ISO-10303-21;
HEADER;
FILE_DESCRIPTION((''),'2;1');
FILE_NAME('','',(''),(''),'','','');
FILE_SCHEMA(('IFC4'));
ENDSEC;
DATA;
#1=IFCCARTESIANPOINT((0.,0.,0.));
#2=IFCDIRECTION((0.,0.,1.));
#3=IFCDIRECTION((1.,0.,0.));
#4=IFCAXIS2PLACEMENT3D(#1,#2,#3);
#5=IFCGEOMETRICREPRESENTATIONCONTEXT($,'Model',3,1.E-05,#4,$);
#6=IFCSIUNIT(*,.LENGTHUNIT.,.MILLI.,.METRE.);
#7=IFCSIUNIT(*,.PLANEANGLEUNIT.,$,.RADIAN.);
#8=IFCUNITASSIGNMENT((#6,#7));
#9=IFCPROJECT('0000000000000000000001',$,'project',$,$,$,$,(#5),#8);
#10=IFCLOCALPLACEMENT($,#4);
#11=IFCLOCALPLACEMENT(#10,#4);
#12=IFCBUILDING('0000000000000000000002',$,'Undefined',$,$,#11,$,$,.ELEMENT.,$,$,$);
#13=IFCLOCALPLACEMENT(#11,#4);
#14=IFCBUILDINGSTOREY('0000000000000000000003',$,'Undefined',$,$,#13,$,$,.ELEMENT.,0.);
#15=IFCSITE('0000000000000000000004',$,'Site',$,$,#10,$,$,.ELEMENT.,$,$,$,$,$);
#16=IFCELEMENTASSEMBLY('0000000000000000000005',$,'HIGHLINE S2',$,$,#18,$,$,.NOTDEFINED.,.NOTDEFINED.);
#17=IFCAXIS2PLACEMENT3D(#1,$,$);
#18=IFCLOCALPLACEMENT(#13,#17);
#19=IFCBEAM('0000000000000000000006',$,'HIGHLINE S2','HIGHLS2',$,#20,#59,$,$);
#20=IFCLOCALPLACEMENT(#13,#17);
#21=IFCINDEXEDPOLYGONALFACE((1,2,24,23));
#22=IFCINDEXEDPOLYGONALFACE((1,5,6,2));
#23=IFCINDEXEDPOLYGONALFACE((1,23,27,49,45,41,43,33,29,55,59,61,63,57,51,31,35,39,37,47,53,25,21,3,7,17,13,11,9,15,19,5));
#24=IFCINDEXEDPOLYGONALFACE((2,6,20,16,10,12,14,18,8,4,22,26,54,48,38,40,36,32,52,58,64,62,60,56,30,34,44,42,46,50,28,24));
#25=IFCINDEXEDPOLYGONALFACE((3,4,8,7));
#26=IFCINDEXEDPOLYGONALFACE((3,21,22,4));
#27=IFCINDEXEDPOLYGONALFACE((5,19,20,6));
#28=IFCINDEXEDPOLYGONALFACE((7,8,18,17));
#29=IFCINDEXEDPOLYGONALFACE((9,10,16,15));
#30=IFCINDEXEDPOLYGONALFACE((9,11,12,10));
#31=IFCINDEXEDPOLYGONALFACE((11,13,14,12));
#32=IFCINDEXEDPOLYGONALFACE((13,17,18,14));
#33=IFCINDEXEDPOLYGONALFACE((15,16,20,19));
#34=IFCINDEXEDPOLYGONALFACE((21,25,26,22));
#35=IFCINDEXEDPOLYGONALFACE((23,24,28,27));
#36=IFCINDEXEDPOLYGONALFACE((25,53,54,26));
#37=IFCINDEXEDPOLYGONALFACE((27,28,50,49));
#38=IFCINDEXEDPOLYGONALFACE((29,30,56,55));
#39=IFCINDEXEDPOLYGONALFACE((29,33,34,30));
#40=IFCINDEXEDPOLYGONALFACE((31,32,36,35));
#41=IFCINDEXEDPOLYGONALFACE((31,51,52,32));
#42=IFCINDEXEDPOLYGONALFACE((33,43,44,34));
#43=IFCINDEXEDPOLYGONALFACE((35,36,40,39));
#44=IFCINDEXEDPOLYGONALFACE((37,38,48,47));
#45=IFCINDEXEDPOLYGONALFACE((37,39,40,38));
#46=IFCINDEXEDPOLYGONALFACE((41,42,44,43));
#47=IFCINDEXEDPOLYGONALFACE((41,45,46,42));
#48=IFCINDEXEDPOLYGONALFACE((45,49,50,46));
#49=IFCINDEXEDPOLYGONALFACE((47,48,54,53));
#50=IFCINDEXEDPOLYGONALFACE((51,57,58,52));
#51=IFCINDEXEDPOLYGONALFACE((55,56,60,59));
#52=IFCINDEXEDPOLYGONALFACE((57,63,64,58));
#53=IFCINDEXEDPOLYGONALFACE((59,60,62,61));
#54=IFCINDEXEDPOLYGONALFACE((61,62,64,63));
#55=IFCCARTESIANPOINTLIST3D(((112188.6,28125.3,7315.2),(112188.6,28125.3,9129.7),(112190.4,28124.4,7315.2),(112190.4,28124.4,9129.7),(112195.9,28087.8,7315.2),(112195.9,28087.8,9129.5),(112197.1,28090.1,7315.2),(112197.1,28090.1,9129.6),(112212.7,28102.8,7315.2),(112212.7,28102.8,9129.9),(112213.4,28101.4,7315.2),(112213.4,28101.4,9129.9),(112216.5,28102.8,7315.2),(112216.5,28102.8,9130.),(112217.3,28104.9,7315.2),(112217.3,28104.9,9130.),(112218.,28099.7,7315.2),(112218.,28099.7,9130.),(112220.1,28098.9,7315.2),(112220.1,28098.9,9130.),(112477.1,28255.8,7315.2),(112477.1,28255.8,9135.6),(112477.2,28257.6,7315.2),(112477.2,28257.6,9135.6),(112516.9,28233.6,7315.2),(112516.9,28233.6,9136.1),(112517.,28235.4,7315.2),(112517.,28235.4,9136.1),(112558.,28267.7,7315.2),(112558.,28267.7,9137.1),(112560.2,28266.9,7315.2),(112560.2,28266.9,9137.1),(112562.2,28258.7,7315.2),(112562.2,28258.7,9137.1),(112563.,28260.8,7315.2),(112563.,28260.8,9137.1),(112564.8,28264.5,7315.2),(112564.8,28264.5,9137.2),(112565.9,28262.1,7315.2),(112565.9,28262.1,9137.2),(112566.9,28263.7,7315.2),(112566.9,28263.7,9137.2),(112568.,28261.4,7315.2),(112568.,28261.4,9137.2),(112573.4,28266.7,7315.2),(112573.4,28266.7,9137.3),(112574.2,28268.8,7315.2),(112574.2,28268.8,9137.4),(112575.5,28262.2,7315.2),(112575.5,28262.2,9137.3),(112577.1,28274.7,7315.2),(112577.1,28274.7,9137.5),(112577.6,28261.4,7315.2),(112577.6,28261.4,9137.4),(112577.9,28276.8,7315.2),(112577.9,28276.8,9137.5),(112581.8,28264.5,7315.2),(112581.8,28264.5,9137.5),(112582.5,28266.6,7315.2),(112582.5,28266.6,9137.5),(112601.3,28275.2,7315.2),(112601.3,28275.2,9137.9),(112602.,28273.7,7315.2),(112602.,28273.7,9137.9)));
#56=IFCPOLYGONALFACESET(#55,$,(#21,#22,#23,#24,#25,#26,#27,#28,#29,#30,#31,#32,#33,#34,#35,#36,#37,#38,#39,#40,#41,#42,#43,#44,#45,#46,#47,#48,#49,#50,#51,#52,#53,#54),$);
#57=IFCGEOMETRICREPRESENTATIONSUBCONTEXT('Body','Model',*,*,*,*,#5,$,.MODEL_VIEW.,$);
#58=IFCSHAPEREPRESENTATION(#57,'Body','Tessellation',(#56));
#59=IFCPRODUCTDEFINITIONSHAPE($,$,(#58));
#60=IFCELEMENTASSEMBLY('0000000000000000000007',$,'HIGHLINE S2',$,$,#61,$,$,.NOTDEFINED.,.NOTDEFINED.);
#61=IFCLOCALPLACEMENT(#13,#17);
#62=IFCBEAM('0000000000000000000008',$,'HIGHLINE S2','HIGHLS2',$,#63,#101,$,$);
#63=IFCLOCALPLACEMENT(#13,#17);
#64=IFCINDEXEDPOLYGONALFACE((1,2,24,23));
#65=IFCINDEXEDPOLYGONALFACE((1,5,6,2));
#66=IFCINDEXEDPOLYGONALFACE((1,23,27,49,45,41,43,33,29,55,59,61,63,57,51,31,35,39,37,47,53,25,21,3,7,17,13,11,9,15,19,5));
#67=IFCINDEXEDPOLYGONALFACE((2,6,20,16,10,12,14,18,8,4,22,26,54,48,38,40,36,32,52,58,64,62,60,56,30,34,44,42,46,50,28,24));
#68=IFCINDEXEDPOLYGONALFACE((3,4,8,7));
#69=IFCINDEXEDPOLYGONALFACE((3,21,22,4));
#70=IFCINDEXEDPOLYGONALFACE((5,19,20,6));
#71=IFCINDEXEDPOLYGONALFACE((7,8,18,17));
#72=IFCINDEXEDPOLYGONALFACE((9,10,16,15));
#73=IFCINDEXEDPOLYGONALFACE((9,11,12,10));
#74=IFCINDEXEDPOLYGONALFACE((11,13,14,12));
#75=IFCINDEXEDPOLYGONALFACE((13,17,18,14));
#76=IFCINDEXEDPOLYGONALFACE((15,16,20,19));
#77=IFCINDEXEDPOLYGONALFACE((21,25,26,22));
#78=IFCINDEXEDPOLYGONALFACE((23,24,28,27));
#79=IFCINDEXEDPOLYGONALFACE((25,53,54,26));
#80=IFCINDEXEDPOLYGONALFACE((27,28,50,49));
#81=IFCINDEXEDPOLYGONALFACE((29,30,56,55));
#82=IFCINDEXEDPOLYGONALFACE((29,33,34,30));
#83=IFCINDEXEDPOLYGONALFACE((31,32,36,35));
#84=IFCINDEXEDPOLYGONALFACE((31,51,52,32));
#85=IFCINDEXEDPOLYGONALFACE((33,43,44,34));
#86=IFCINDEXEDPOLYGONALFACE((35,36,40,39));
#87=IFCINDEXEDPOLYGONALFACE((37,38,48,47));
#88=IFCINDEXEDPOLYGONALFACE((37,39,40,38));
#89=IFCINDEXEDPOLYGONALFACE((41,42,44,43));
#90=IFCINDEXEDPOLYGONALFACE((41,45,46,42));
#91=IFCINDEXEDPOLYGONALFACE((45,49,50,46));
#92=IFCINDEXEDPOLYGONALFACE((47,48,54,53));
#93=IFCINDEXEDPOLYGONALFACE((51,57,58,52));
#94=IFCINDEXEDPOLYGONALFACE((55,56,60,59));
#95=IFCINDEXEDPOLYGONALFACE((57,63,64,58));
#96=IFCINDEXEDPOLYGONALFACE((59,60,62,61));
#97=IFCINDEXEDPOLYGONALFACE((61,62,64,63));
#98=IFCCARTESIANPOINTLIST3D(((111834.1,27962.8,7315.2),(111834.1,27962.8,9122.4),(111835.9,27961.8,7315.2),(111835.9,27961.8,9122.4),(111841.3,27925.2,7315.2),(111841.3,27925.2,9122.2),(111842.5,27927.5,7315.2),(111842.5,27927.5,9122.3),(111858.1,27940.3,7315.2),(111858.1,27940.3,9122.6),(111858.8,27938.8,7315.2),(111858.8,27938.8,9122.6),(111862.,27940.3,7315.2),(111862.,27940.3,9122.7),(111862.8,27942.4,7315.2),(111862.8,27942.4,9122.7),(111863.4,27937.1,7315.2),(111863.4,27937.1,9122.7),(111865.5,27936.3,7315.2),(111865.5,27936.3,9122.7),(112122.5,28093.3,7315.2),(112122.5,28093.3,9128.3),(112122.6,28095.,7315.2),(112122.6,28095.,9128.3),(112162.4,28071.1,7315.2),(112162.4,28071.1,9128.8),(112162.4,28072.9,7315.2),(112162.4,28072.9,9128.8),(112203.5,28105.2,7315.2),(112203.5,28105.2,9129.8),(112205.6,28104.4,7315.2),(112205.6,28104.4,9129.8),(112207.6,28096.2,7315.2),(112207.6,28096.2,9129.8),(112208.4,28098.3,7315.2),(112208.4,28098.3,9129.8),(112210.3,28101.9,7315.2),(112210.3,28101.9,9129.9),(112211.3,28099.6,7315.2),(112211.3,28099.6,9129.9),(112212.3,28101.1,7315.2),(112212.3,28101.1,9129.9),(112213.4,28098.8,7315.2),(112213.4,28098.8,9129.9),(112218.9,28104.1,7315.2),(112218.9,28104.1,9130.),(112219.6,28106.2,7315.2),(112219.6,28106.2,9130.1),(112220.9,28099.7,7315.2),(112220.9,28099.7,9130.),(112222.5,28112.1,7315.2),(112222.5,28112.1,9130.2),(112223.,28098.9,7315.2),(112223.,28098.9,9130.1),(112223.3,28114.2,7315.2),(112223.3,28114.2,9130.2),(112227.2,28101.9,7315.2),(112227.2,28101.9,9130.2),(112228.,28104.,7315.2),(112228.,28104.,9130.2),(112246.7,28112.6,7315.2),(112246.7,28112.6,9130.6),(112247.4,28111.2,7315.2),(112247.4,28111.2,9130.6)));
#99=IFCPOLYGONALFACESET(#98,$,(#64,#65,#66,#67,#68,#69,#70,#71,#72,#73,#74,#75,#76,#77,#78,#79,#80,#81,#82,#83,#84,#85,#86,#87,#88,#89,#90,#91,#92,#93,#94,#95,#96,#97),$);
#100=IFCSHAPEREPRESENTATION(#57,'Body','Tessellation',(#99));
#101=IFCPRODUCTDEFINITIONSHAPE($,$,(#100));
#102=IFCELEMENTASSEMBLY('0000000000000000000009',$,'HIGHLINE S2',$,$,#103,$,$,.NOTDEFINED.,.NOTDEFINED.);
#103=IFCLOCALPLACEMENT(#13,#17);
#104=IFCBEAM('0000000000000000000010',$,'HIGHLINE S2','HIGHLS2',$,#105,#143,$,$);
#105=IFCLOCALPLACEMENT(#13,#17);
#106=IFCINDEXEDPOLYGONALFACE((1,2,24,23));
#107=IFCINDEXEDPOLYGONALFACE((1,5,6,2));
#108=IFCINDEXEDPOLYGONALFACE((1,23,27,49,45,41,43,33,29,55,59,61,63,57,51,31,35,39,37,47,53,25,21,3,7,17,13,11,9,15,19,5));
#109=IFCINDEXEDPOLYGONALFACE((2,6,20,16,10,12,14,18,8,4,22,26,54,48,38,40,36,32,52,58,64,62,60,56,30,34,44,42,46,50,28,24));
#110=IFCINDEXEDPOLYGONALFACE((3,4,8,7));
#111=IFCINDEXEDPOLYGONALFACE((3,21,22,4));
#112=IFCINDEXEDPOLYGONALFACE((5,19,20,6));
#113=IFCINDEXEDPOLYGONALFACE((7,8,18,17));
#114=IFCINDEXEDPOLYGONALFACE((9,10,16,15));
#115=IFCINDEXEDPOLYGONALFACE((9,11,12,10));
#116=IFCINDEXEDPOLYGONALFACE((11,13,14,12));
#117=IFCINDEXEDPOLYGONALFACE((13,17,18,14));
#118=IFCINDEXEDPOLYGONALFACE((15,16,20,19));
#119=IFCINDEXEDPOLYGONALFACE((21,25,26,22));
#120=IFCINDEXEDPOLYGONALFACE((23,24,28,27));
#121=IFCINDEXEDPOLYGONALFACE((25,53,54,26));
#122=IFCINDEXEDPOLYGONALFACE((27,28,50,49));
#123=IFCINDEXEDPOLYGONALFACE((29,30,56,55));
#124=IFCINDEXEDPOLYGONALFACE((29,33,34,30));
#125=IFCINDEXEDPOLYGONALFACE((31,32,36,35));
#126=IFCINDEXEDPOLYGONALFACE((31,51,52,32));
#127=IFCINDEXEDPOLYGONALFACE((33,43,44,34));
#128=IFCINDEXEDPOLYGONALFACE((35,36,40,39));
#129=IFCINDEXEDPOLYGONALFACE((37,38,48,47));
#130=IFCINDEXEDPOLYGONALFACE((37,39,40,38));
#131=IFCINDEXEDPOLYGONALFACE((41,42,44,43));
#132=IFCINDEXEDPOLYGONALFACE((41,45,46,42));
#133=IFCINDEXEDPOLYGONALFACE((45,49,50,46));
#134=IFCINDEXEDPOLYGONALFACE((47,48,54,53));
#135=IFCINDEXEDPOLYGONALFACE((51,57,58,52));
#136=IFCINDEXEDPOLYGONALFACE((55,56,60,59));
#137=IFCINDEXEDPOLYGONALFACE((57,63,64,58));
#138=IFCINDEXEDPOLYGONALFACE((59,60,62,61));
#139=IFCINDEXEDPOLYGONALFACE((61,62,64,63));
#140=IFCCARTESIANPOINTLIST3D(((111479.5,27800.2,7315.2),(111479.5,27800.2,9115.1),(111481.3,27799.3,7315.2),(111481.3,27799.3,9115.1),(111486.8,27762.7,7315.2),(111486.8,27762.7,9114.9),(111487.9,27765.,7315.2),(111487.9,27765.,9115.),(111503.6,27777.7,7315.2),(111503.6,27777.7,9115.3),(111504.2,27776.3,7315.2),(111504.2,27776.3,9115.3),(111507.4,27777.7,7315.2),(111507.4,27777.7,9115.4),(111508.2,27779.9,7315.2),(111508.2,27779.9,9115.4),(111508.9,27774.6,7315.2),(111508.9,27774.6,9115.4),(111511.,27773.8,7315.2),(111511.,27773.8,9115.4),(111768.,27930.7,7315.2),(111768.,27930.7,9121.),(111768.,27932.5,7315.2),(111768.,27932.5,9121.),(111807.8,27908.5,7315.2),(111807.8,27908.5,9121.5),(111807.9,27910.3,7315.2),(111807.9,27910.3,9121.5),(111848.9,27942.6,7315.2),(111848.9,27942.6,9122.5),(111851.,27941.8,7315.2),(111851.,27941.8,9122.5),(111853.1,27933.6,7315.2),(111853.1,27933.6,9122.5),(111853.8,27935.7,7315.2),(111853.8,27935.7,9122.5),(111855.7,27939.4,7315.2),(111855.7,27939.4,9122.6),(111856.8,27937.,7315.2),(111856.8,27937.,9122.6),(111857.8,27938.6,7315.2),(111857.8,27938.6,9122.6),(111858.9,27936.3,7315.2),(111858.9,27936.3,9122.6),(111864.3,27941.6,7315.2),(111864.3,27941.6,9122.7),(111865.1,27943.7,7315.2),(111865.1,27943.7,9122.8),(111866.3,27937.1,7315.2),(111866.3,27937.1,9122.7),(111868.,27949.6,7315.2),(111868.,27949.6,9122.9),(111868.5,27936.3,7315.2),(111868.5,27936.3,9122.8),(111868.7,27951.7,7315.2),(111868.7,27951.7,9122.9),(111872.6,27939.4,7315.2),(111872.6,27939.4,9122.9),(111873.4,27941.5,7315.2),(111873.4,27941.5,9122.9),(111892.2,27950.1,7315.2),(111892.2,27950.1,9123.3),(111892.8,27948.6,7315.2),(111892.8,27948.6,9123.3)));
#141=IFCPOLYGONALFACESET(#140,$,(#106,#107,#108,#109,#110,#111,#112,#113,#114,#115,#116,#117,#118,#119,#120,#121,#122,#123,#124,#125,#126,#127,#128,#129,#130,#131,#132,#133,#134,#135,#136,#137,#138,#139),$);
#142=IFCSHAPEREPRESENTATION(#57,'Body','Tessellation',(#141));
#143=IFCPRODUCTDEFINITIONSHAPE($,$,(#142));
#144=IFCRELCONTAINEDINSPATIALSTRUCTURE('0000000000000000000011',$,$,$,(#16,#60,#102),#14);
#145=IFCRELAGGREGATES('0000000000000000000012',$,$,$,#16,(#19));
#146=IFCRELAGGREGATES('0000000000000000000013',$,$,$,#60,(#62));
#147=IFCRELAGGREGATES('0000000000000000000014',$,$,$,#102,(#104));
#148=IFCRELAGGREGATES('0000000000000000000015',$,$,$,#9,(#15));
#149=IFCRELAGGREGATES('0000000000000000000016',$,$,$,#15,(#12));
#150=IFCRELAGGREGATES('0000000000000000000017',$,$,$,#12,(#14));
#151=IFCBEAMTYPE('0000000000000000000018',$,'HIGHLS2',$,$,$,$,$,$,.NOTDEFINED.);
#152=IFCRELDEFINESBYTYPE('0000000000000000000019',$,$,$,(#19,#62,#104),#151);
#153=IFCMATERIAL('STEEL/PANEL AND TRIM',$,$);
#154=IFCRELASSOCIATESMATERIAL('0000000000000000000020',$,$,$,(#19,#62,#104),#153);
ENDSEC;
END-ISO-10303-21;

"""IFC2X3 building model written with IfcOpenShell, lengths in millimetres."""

from ifc_helpers import new_model, si_unit, frame, origin_with_axes, place, context, subcontext, project, spatial, polyline, outline, extrude, boolean, halfspace, material, type_object, element, aggregate, save


model = new_model("IFC2X3")

# Units and contexts
model_context = context("Model", 3, precision=1e-05, world=origin_with_axes())
body_context = subcontext(model_context, "Body", "Model", "MODEL_VIEW")
ifc_project = project(units=[si_unit("LENGTHUNIT", "METRE", prefix="MILLI"), si_unit("PLANEANGLEUNIT", "RADIAN")], contexts=[model_context])

# Site, building, storey
site_placement = place(None, origin_with_axes())
site = spatial("IfcSite", under=ifc_project, at=site_placement, Name="Site", CompositionType="ELEMENT")
building_placement = place(site_placement, origin_with_axes())
building = spatial("IfcBuilding", under=site, at=building_placement, Name="Undefined", CompositionType="ELEMENT")
storey_placement = place(building_placement, origin_with_axes())
storey = spatial("IfcBuildingStorey", under=building, at=storey_placement, Name="Undefined", CompositionType="ELEMENT", Elevation=0.0)

# Element assemblies, beams
ifc_material_1 = material(Name="STEEL/PANEL AND TRIM")
beam_type_1 = type_object("IfcBeamType", Name="HIGHLS2", PredefinedType="NOTDEFINED")
assembly_1_placement = place(storey_placement, origin_with_axes())
assembly_1 = element("IfcElementAssembly", 1, at=assembly_1_placement, inside=storey, Name="HIGHLINE S2", AssemblyPlace="NOTDEFINED", PredefinedType="NOTDEFINED")
beam_1_placement = place(assembly_1_placement, frame((112188.6, 28125.3, 4267.2), z_axis=(0.41674, -0.909026, 0.0), x_axis=(0.0, 0.0, 1.0)))
beam_1 = element("IfcBeam", 2, at=beam_1_placement, type_object=beam_type_1, material=ifc_material_1, Name="HIGHLINE S2", Description="HIGHLS2", context=body_context, shape_type="CSG", body=[
    boolean("DIFFERENCE", boolean("DIFFERENCE", extrude(outline(polyline([(415.4, 26.1), (415.4, 37.3), (437.6, 37.3), (437.6, 35.7), (417.0, 35.7), (417.0, 24.5), (395.1, 24.5), (395.1, 34.4), (401.5, 34.4), (401.5, 31.9), (408.7, 31.9), (408.7, 36.8), (344.4, 36.8), (317.4, 0.0), (0.0, 0.0), (-9.0, 37.1), (17.6, 37.1), (17.6, 30.5), (12.5, 30.5), (12.5, 32.1), (16.0, 32.1), (16.0, 35.5), (-7.0, 35.5), (1.2, 1.6), (316.6, 1.6), (343.6, 38.4), (410.3, 38.4), (410.3, 30.3), (400.0, 30.3), (400.0, 32.8), (396.7, 32.8), (396.7, 26.1), (415.4, 26.1)])), frame((10000.0, 0.0, 0.0), z_axis=(-1.0, 0.0, 0.0), x_axis=(0.0, -1.0, 0.0)), (0.0, 0.0, 1.0), 10000.0), extrude(outline(polyline([(0.0, 0.0), (6400.8, 0.0), (6400.8, 3048.0), (0.0, 3048.0), (0.0, 0.0)])), frame((0.0, 1096.1, -9.8), z_axis=(0.0, 0.0, 1.0), x_axis=(0.0, -1.0, 0.0)), (0.0, 0.0, 1.0), 58.0)), halfspace(frame((4853.1, 500.0, 500.0), z_axis=(0.999825, 0.018709, 0.0), x_axis=(0.0, 0.0, -1.0)), False)),
])
aggregate(assembly_1, [beam_1])
assembly_2_placement = place(storey_placement, origin_with_axes())
assembly_2 = element("IfcElementAssembly", 3, at=assembly_2_placement, inside=storey, Name="HIGHLINE S2", AssemblyPlace="NOTDEFINED", PredefinedType="NOTDEFINED")
beam_2_placement = place(assembly_2_placement, frame((111834.1, 27962.8, 4267.2), z_axis=(0.41674, -0.909026, 0.0), x_axis=(0.0, 0.0, 1.0)))
beam_2 = element("IfcBeam", 4, at=beam_2_placement, type_object=beam_type_1, material=ifc_material_1, Name="HIGHLINE S2", Description="HIGHLS2", context=body_context, shape_type="CSG", body=[
    boolean("DIFFERENCE", boolean("DIFFERENCE", extrude(outline(polyline([(415.4, 26.1), (415.4, 37.3), (437.6, 37.3), (437.6, 35.7), (417.0, 35.7), (417.0, 24.5), (395.1, 24.5), (395.1, 34.4), (401.5, 34.4), (401.5, 31.9), (408.7, 31.9), (408.7, 36.8), (344.4, 36.8), (317.4, 0.0), (0.0, 0.0), (-9.0, 37.1), (17.6, 37.1), (17.6, 30.5), (12.5, 30.5), (12.5, 32.1), (16.0, 32.1), (16.0, 35.5), (-7.0, 35.5), (1.2, 1.6), (316.6, 1.6), (343.6, 38.4), (410.3, 38.4), (410.3, 30.3), (400.0, 30.3), (400.0, 32.8), (396.7, 32.8), (396.7, 26.1), (415.4, 26.1)])), frame((10000.0, 0.0, 0.0), z_axis=(-1.0, 0.0, 0.0), x_axis=(0.0, -1.0, 0.0)), (0.0, 0.0, 1.0), 10000.0), extrude(outline(polyline([(0.0, 0.0), (6400.8, 0.0), (6400.8, 3048.0), (0.0, 3048.0), (0.0, 0.0)])), frame((0.0, 706.1, -9.8), z_axis=(0.0, 0.0, 1.0), x_axis=(0.0, -1.0, 0.0)), (0.0, 0.0, 1.0), 58.0)), halfspace(frame((4845.8, 500.0, 500.0), z_axis=(0.999825, 0.018709, 0.0), x_axis=(0.0, 0.0, -1.0)), False)),
])
aggregate(assembly_2, [beam_2])
assembly_3_placement = place(storey_placement, origin_with_axes())
assembly_3 = element("IfcElementAssembly", 5, at=assembly_3_placement, inside=storey, Name="HIGHLINE S2", AssemblyPlace="NOTDEFINED", PredefinedType="NOTDEFINED")
beam_3_placement = place(assembly_3_placement, frame((111479.5, 27800.2, 4267.2), z_axis=(0.41674, -0.909026, 0.0), x_axis=(0.0, 0.0, 1.0)))
beam_3 = element("IfcBeam", 6, at=beam_3_placement, type_object=beam_type_1, material=ifc_material_1, Name="HIGHLINE S2", Description="HIGHLS2", context=body_context, shape_type="CSG", body=[
    boolean("DIFFERENCE", boolean("DIFFERENCE", extrude(outline(polyline([(415.4, 26.1), (415.4, 37.3), (437.6, 37.3), (437.6, 35.7), (417.0, 35.7), (417.0, 24.5), (395.1, 24.5), (395.1, 34.4), (401.5, 34.4), (401.5, 31.9), (408.7, 31.9), (408.7, 36.8), (344.4, 36.8), (317.4, 0.0), (0.0, 0.0), (-9.0, 37.1), (17.6, 37.1), (17.6, 30.5), (12.5, 30.5), (12.5, 32.1), (16.0, 32.1), (16.0, 35.5), (-7.0, 35.5), (1.2, 1.6), (316.6, 1.6), (343.6, 38.4), (410.3, 38.4), (410.3, 30.3), (400.0, 30.3), (400.0, 32.8), (396.7, 32.8), (396.7, 26.1), (415.4, 26.1)])), frame((10000.0, 0.0, 0.0), z_axis=(-1.0, 0.0, 0.0), x_axis=(0.0, -1.0, 0.0)), (0.0, 0.0, 1.0), 10000.0), extrude(outline(polyline([(0.0, 0.0), (6400.8, 0.0), (6400.8, 3048.0), (0.0, 3048.0), (0.0, 0.0)])), frame((0.0, 316.1, -9.8), z_axis=(0.0, 0.0, 1.0), x_axis=(0.0, -1.0, 0.0)), (0.0, 0.0, 1.0), 58.0)), halfspace(frame((4838.5, 500.0, 500.0), z_axis=(0.999825, 0.018709, 0.0), x_axis=(0.0, 0.0, -1.0)), False)),
])
aggregate(assembly_3, [beam_3])

save(model, "model.ifc")
